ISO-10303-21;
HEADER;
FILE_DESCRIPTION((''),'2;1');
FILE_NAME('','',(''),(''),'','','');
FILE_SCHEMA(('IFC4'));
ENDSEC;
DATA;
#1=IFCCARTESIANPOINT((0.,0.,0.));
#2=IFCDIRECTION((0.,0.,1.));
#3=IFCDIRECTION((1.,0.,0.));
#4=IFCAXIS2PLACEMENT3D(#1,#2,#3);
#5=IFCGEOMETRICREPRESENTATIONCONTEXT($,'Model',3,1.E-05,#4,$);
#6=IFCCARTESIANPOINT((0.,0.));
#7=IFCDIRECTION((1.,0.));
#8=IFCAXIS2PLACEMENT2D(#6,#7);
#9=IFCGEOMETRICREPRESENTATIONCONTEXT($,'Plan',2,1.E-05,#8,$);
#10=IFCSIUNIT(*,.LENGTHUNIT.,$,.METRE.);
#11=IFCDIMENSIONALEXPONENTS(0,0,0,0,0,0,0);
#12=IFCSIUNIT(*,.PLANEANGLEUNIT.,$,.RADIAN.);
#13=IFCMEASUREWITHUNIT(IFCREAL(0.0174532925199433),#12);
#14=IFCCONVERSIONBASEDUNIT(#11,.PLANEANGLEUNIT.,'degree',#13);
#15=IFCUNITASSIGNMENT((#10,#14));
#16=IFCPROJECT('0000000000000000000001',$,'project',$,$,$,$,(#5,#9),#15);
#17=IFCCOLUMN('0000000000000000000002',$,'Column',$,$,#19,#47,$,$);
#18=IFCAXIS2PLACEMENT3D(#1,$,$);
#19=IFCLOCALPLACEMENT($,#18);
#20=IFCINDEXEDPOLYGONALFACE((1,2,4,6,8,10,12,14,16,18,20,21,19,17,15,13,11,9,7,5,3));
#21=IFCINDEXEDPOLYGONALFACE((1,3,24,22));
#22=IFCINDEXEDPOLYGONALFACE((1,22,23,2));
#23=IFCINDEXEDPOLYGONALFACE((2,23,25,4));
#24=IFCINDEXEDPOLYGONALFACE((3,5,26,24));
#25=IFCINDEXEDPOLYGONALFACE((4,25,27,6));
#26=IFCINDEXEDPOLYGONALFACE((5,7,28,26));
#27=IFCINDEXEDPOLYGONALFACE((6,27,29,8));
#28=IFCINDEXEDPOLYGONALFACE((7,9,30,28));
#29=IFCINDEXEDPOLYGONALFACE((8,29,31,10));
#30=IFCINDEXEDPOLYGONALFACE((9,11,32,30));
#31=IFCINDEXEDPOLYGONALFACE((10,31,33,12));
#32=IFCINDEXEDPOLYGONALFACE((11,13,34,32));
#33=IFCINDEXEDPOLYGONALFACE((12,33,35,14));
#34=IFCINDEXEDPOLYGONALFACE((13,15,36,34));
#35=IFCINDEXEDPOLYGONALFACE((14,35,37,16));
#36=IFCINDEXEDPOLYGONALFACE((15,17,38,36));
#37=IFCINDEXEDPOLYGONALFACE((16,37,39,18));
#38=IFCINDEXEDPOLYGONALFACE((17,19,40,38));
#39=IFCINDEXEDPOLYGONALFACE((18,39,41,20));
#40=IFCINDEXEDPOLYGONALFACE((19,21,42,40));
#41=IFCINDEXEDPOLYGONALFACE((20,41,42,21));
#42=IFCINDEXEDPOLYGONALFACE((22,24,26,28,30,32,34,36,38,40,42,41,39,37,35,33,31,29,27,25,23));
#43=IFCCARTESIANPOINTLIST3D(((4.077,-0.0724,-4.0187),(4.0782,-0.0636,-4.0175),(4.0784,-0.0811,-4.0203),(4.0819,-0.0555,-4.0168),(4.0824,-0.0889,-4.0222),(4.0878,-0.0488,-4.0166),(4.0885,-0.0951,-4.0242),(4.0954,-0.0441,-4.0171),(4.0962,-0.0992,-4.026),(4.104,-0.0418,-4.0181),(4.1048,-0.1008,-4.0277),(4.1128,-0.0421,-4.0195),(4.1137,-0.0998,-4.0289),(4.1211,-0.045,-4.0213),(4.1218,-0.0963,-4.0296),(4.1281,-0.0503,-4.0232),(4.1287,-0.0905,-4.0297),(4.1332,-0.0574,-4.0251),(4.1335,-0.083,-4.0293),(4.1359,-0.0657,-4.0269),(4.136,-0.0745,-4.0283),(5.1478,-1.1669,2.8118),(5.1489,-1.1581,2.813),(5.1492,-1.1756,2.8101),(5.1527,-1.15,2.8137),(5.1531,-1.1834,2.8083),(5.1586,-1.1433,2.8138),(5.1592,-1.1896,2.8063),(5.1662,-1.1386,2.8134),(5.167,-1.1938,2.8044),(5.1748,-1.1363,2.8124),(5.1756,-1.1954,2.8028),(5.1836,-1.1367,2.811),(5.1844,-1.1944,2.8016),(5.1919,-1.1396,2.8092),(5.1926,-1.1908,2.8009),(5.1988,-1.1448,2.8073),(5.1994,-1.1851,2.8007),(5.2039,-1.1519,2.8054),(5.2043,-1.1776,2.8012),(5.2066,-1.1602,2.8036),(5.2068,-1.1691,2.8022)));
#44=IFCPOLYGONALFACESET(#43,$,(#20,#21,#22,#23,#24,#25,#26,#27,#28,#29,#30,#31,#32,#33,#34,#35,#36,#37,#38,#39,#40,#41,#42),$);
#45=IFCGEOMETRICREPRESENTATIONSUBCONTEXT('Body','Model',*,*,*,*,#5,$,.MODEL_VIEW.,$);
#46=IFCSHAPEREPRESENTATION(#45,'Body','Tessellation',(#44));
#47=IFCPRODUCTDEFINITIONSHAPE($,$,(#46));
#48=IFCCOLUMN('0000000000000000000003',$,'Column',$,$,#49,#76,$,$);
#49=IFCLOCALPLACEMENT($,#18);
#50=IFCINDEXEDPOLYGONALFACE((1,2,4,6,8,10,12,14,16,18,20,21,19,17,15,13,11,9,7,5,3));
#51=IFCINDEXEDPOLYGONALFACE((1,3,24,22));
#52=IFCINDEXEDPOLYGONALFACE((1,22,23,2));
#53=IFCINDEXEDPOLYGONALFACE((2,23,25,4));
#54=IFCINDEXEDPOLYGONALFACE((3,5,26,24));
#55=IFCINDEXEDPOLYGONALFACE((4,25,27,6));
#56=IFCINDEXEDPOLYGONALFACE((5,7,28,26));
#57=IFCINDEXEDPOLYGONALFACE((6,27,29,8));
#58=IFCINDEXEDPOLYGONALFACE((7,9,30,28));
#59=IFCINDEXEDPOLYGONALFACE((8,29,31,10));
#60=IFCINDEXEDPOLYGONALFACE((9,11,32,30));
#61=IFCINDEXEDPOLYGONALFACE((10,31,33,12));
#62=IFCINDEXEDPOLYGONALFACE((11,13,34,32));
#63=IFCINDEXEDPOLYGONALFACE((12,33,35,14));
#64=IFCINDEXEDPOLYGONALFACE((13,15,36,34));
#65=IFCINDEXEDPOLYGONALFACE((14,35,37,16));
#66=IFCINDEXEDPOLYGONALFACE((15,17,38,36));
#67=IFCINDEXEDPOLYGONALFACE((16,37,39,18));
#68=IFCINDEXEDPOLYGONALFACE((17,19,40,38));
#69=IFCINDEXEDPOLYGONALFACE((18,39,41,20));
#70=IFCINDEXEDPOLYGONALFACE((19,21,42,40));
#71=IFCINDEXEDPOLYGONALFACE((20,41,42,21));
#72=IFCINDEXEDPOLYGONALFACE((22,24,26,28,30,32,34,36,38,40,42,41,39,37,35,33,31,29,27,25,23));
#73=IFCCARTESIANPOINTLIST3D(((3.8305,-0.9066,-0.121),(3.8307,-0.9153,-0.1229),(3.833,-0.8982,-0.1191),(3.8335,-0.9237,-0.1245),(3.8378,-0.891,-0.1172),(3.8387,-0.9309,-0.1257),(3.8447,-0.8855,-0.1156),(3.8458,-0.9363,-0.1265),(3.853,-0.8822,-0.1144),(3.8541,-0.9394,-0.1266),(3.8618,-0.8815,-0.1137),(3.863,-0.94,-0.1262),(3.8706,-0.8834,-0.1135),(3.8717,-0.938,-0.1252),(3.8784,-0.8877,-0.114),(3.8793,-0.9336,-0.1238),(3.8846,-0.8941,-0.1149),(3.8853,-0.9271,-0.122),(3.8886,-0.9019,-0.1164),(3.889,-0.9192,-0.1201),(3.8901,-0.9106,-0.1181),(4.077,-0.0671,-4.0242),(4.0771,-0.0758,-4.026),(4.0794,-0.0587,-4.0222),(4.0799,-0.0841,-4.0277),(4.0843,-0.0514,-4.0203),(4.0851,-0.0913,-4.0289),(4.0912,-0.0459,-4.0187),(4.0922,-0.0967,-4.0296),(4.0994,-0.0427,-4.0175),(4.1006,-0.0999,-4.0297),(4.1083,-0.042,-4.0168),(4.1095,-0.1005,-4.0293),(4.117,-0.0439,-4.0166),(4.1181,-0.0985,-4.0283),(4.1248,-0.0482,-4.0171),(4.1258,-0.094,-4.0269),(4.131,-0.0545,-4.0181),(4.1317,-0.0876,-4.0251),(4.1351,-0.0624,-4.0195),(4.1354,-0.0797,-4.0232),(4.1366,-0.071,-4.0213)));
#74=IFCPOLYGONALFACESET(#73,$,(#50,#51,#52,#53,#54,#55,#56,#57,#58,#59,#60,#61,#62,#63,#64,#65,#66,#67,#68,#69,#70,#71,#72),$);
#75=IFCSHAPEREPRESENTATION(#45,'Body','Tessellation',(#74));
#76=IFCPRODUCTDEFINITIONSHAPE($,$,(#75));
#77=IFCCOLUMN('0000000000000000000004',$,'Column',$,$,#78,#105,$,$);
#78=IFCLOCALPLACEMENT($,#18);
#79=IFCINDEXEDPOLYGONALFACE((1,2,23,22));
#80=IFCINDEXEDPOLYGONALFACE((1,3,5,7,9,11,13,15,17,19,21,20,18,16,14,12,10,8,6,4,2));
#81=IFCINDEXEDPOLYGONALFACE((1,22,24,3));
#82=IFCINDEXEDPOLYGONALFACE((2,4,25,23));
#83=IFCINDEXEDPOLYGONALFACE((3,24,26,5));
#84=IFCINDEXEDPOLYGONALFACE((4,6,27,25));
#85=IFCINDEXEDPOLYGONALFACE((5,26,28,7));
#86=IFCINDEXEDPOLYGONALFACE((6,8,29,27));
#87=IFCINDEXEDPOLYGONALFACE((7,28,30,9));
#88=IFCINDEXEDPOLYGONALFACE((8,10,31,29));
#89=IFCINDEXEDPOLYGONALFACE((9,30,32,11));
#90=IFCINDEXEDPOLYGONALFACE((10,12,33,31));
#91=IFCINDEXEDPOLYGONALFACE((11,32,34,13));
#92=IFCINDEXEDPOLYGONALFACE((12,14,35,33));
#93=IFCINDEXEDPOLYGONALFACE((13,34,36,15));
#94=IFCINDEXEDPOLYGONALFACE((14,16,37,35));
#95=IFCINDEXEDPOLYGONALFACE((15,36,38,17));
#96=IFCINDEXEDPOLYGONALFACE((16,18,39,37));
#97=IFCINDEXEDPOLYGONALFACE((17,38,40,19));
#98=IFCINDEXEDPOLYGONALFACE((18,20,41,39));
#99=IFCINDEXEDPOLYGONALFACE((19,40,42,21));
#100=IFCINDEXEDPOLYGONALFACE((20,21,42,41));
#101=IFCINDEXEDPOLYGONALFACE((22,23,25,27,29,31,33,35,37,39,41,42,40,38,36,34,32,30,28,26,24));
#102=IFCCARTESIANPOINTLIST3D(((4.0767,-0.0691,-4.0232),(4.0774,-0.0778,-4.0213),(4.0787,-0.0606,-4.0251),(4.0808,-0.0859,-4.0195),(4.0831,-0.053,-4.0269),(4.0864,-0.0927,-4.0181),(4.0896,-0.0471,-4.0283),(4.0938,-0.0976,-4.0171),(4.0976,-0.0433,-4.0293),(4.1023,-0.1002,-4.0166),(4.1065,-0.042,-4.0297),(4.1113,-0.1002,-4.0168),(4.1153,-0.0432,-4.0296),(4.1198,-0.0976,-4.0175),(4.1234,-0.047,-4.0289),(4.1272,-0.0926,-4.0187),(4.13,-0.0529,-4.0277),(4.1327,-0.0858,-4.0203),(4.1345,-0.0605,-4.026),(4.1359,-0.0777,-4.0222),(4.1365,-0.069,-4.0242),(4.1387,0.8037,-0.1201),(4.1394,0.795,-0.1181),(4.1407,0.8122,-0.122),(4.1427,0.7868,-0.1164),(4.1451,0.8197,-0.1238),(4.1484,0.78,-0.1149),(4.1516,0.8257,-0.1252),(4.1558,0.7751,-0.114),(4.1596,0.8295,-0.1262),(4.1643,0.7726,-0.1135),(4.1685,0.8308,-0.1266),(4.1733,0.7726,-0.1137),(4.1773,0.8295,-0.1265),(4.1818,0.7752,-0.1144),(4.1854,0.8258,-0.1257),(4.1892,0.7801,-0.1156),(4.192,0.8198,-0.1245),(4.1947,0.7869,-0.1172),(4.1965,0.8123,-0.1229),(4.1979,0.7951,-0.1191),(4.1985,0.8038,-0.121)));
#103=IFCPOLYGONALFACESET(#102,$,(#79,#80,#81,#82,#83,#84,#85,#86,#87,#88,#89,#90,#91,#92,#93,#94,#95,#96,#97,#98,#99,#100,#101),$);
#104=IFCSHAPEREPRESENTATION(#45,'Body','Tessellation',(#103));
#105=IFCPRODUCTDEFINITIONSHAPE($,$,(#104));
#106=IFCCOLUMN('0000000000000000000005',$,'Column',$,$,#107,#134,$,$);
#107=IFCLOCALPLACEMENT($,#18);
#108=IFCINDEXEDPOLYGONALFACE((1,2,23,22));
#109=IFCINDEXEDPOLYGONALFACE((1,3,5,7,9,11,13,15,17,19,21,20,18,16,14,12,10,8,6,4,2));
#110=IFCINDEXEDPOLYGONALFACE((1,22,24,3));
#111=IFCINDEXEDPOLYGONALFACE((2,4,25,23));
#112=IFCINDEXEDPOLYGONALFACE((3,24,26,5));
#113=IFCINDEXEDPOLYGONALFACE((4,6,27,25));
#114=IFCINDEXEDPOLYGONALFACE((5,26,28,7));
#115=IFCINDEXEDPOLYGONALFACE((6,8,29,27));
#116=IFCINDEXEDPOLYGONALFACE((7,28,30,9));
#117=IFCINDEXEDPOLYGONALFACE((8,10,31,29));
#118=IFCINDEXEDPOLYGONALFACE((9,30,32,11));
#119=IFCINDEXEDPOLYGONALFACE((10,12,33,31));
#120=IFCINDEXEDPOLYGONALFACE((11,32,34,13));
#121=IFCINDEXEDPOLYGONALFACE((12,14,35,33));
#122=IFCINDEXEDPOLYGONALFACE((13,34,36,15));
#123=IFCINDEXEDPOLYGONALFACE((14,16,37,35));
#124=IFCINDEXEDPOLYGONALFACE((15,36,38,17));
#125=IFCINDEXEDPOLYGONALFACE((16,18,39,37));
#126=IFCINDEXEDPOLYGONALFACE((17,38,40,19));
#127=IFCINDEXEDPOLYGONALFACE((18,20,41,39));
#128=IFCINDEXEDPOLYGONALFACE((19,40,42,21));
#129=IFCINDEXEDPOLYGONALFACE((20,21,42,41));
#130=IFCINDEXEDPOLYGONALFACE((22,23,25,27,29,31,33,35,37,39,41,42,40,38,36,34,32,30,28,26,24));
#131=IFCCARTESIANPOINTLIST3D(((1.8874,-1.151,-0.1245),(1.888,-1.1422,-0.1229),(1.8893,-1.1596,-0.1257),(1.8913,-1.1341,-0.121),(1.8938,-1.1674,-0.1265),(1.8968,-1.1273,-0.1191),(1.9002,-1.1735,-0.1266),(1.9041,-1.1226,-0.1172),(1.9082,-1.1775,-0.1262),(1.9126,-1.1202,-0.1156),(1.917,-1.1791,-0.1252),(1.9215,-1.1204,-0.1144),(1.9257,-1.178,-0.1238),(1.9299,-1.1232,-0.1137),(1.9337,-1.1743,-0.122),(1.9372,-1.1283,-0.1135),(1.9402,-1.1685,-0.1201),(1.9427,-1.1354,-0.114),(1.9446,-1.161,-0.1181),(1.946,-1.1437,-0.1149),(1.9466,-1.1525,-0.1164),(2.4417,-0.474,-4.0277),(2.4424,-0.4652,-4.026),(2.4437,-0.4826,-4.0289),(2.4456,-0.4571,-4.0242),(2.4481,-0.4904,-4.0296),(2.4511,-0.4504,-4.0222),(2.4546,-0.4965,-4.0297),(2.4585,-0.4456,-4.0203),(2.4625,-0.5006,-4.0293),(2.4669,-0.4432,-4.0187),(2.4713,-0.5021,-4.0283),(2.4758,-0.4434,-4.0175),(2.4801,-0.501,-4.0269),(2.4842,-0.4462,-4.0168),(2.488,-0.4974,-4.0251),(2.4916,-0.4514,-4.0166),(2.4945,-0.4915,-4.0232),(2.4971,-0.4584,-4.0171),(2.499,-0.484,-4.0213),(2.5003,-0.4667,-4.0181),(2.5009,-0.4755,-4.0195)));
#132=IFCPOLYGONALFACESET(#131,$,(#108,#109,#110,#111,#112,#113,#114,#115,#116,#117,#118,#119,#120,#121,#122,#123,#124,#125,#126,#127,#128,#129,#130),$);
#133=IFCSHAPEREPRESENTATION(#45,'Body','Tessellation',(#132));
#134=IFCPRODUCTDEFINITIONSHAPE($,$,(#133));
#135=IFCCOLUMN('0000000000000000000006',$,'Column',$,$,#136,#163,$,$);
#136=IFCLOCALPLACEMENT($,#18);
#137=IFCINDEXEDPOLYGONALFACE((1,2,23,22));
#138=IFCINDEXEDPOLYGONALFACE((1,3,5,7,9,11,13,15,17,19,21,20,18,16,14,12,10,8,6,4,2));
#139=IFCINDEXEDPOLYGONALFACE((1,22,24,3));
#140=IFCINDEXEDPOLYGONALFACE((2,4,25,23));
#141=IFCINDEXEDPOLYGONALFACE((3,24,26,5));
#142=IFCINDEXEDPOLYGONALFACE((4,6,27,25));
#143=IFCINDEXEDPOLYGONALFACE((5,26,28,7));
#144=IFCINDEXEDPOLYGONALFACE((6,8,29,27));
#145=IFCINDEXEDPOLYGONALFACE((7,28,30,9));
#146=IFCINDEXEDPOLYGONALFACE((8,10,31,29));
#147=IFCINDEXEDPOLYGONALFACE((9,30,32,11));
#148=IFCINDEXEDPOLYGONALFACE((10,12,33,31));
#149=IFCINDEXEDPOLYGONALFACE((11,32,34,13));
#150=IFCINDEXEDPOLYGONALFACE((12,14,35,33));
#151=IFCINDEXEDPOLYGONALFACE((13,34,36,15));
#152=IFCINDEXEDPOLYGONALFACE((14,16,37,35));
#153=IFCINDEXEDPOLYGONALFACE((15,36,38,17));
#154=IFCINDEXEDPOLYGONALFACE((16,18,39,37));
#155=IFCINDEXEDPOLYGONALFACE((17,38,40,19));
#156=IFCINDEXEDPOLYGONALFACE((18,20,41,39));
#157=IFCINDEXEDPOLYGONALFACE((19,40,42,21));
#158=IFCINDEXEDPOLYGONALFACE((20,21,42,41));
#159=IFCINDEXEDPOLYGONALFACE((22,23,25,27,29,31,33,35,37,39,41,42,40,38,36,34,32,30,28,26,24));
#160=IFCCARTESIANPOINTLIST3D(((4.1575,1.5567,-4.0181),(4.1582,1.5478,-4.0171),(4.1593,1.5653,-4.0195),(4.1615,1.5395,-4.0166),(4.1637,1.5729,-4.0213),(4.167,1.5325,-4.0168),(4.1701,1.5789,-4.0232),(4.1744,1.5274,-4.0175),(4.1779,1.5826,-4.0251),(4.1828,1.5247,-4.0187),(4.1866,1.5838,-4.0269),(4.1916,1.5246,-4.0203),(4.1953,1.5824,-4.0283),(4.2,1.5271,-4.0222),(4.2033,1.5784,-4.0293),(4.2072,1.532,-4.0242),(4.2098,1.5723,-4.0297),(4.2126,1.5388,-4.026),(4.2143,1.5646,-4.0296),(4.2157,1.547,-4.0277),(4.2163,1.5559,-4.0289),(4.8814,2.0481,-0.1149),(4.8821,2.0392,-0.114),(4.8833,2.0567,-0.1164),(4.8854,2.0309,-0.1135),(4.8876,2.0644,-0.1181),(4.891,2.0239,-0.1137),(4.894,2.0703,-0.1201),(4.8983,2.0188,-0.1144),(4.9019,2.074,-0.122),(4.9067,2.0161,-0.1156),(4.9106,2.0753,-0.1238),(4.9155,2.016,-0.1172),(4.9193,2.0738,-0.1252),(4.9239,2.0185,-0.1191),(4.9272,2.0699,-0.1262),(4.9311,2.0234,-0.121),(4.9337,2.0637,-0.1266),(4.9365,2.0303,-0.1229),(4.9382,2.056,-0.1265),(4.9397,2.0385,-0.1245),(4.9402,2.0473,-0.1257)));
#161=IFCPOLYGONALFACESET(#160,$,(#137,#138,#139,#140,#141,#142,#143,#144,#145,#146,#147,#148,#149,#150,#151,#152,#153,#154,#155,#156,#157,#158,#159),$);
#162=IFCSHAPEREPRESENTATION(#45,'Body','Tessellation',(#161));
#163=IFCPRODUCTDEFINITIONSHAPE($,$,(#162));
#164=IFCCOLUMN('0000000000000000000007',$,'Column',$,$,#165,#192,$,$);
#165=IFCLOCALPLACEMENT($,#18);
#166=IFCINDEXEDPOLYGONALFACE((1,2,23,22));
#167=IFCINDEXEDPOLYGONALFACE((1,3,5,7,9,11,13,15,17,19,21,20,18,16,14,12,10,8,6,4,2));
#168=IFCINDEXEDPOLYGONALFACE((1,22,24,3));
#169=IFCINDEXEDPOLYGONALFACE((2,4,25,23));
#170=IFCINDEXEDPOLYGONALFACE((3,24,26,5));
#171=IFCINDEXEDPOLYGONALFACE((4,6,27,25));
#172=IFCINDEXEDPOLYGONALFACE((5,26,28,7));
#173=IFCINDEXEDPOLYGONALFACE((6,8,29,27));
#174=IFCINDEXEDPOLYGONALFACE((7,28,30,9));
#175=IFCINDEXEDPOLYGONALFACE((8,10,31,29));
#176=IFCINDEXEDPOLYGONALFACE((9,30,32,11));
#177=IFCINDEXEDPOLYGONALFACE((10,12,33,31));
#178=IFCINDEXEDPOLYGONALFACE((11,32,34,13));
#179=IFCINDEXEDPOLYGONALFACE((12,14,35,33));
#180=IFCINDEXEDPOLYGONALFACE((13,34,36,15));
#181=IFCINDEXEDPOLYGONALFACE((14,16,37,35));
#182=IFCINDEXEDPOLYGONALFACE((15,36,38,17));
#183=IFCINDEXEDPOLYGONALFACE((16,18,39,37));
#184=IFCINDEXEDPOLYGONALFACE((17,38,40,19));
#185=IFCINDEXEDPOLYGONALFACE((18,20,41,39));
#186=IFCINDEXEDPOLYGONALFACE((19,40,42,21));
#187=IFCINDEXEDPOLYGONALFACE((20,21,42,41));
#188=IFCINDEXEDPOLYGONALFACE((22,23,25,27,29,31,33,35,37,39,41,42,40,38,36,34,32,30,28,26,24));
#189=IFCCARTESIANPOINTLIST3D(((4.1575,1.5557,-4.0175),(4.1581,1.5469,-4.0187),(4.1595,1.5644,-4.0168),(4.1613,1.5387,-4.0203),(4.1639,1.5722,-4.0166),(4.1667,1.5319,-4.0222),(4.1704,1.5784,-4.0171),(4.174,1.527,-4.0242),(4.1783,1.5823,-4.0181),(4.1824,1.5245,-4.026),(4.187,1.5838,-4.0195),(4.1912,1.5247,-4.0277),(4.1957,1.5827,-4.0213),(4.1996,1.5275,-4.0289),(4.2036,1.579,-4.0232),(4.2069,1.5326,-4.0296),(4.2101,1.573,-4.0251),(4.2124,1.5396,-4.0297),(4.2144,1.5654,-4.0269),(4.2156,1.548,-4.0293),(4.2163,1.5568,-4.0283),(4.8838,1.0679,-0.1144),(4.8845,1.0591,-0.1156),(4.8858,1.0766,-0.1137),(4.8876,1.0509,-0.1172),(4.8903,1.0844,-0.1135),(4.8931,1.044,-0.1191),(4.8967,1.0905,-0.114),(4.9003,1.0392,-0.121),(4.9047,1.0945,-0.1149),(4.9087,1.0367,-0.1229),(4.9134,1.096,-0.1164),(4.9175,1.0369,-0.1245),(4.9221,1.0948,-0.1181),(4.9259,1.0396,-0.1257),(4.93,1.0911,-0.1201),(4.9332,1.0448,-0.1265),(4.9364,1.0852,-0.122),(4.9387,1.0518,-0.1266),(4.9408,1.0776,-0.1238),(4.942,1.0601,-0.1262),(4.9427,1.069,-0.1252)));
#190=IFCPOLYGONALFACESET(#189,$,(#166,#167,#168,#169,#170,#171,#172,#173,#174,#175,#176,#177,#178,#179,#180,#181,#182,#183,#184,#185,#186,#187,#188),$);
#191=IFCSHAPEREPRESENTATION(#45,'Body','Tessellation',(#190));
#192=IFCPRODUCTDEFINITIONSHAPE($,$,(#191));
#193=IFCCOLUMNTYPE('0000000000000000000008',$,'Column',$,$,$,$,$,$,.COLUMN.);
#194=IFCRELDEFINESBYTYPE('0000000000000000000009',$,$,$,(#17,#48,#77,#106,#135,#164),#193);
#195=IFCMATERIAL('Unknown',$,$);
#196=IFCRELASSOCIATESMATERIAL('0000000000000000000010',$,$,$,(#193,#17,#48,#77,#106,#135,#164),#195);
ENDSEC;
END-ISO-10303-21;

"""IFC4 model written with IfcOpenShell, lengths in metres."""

from ifc_helpers import new_model, entity, si_unit, converted_unit, frame, origin_with_axes, origin_2d_with_axis, place, context, subcontext, project, circle, extrude, material, material_profile, profile_set, profile_usage, type_object, element, save


model = new_model("IFC4")

# Units and contexts
model_context = context("Model", 3, precision=1e-05, world=origin_with_axes())
plan_context = context("Plan", 2, precision=1e-05, world=origin_2d_with_axis())
body_context = subcontext(model_context, "Body", "Model", "MODEL_VIEW")
ifc_project = project(units=[si_unit("LENGTHUNIT", "METRE"), converted_unit("PLANEANGLEUNIT", "degree", entity("IfcReal", 0.0174532925199433), si_unit("PLANEANGLEUNIT", "RADIAN"), dimensions=[0, 0, 0, 0, 0, 0, 0])], contexts=[model_context, plan_context])

# Columns
ifc_material = material(Name="Unknown")
ifc_material_profile = material_profile(ifc_material, circle(Radius=0.03))
ifc_profile_set = profile_set([ifc_material_profile])
ifc_profile_usage_1 = profile_usage(ifc_profile_set, cardinal=5)
column_type = type_object("IfcColumnType", Name="Column", PredefinedType="COLUMN", material=ifc_profile_set)
column_1_placement = place(None, frame((4.1066, -0.0712, -4.0232), z_axis=(0.152964, -0.156363, 0.975783), x_axis=(0.714834, 0.699294, 0.0)))
element("IfcColumn", 1, at=column_1_placement, type_object=column_type, material=ifc_profile_usage_1, Name="Column", context=body_context, shape_type="SweptSolid", body=[
    extrude(circle(Radius=0.03), origin_with_axes(), (0.0, 0.0, 1.0), 7.0),
])
ifc_profile_usage_2 = profile_usage(ifc_profile_set, cardinal=5)
column_2_placement = place(None, frame((4.1066, -0.0712, -4.0232), z_axis=(-0.061611, -0.209885, 0.975783), x_axis=(0.959514, -0.28166, 0.0)))
element("IfcColumn", 2, at=column_2_placement, type_object=column_type, material=ifc_profile_usage_2, Name="Column", context=body_context, shape_type="SweptSolid", body=[
    extrude(circle(Radius=0.03), origin_with_axes(), (0.0, 0.0, 1.0), 4.0),
])
ifc_profile_usage_3 = profile_usage(ifc_profile_set, cardinal=5)
column_3_placement = place(None, frame((4.1066, -0.0712, -4.0232), z_axis=(0.015497, 0.218191, 0.975783), x_axis=(-0.997487, 0.070849, 0.0)))
element("IfcColumn", 3, at=column_3_placement, type_object=column_type, material=ifc_profile_usage_3, Name="Column", context=body_context, shape_type="SweptSolid", body=[
    extrude(circle(Radius=0.03), origin_with_axes(), (0.0, 0.0, 1.0), 4.0),
])
ifc_profile_usage_4 = profile_usage(ifc_profile_set, cardinal=5)
column_4_placement = place(None, frame((2.4713, -0.4725, -4.0232), z_axis=(-0.13858, -0.169243, 0.975783), x_axis=(0.773715, -0.633534, 0.0)))
element("IfcColumn", 4, at=column_4_placement, type_object=column_type, material=ifc_profile_usage_4, Name="Column", context=body_context, shape_type="SweptSolid", body=[
    extrude(circle(Radius=0.03), origin_with_axes(), (0.0, 0.0, 1.0), 4.0),
])
ifc_profile_usage_5 = profile_usage(ifc_profile_set, cardinal=5)
column_5_placement = place(None, frame((4.1869, 1.5541, -4.0232), z_axis=(0.18098, 0.122856, 0.975783), x_axis=(-0.561651, 0.827374, 0.0)))
element("IfcColumn", 5, at=column_5_placement, type_object=column_type, material=ifc_profile_usage_5, Name="Column", context=body_context, shape_type="SweptSolid", body=[
    extrude(circle(Radius=0.03), origin_with_axes(), (0.0, 0.0, 1.0), 4.0),
])
ifc_profile_usage_6 = profile_usage(ifc_profile_set, cardinal=5)
column_6_placement = place(None, frame((4.1869, 1.5541, -4.0232), z_axis=(0.181584, -0.121961, 0.975783), x_axis=(0.557562, 0.830136, 0.0)))
element("IfcColumn", 6, at=column_6_placement, type_object=column_type, material=ifc_profile_usage_6, Name="Column", context=body_context, shape_type="SweptSolid", body=[
    extrude(circle(Radius=0.03), origin_with_axes(), (0.0, 0.0, 1.0), 4.0),
])

save(model, "model.ifc")
